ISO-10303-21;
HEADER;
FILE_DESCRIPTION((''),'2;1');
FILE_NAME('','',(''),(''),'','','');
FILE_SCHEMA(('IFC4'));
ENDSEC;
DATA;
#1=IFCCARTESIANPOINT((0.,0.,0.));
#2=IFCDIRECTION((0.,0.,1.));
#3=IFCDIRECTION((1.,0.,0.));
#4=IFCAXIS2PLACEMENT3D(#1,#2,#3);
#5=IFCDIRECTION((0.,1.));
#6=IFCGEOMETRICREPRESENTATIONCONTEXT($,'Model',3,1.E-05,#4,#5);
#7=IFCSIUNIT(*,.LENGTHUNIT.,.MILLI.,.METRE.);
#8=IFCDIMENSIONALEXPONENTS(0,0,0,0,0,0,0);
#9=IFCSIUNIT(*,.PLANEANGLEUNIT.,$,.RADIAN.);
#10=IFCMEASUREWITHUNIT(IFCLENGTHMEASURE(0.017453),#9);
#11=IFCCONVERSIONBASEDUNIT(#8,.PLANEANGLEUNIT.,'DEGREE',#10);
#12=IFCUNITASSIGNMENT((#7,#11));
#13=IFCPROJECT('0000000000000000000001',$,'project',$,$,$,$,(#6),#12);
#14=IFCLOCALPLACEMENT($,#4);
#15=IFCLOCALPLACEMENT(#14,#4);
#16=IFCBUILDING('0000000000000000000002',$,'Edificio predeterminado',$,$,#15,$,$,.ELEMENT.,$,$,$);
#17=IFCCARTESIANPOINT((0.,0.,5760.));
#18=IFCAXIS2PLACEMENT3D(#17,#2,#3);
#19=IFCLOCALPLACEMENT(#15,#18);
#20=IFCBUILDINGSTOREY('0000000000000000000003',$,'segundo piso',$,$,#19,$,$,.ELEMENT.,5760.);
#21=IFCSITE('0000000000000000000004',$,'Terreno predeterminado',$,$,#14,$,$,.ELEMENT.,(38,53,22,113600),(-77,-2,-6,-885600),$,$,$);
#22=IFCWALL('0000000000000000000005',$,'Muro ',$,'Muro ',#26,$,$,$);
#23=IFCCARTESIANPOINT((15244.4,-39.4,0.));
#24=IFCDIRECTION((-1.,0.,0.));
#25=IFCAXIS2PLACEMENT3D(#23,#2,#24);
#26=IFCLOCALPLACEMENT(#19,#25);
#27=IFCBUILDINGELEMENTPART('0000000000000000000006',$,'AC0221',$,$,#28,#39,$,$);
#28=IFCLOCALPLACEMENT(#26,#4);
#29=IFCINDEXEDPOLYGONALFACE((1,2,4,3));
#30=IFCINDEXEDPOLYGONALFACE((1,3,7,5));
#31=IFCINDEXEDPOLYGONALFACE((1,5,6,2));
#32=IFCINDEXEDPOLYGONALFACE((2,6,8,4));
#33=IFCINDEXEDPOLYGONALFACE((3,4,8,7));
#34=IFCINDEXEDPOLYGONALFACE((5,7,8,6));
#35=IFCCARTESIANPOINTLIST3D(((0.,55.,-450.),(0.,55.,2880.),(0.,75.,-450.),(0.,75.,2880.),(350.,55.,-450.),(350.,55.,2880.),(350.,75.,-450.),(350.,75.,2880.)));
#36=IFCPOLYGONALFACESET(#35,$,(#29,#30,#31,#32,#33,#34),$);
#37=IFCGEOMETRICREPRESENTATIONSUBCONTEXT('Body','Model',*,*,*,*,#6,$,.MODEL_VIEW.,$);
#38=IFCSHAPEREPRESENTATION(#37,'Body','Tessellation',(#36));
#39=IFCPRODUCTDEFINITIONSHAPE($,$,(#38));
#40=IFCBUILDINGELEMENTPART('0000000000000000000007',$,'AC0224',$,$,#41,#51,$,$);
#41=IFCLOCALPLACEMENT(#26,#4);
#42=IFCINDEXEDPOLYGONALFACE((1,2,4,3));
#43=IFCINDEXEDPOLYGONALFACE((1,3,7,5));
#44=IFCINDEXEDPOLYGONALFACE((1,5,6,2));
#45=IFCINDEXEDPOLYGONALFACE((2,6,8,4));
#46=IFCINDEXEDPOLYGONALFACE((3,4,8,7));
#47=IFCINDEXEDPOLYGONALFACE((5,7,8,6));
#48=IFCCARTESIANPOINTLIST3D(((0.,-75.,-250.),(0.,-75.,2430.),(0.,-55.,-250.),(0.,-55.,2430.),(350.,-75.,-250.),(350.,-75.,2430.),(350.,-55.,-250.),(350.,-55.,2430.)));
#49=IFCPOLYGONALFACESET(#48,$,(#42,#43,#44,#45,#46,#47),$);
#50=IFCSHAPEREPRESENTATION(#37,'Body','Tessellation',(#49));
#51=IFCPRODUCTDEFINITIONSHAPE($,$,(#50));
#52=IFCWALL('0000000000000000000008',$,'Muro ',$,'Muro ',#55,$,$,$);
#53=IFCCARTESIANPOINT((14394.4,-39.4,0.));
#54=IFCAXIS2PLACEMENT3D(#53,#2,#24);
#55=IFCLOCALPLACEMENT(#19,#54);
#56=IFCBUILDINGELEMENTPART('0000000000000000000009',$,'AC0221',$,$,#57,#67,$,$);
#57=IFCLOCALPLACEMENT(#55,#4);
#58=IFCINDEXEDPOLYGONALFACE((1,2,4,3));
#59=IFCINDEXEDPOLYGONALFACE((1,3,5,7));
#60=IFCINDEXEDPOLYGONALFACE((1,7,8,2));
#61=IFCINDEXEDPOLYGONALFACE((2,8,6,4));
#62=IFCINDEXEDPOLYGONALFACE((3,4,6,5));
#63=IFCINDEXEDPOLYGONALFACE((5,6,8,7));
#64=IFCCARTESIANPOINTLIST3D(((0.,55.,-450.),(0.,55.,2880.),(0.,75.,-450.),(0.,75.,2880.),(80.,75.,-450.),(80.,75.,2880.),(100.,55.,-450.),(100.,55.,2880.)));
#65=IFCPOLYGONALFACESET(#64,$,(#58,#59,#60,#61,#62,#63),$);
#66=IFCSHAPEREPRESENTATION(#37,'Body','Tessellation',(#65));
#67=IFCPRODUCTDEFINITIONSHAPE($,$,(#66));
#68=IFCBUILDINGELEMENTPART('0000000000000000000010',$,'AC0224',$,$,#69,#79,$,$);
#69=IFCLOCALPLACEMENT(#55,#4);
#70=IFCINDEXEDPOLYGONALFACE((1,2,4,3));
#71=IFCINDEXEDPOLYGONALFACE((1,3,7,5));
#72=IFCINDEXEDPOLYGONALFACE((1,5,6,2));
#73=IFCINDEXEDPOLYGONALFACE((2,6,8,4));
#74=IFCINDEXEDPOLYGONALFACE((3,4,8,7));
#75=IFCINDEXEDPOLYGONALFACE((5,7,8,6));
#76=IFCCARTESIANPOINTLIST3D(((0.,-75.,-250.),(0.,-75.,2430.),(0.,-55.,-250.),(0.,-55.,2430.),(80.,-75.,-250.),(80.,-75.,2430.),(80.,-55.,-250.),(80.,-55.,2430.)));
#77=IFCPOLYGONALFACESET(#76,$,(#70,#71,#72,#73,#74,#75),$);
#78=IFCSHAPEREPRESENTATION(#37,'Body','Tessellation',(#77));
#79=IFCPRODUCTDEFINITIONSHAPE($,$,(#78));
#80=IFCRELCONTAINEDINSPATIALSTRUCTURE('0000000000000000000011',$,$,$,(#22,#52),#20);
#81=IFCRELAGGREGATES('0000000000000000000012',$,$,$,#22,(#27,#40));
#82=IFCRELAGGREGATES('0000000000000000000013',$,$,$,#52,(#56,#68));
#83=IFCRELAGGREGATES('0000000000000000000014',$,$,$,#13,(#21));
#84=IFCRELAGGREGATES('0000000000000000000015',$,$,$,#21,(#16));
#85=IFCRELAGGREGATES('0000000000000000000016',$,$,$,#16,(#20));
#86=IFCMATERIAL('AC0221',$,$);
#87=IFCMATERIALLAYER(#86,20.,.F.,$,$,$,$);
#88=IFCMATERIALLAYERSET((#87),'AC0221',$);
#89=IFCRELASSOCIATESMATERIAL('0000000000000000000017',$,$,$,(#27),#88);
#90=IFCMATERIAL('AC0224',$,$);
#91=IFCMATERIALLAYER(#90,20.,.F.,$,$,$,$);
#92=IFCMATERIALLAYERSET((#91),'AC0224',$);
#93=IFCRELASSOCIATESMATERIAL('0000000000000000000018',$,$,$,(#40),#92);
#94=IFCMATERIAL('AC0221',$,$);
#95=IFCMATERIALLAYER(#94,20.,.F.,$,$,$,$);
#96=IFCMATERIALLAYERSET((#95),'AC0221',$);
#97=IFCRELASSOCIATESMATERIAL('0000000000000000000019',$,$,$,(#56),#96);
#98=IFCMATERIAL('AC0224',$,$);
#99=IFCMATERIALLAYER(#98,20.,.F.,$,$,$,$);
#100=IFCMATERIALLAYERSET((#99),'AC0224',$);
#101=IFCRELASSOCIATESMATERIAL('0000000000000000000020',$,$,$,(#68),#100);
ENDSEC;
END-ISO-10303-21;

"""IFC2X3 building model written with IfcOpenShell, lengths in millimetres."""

from ifc_helpers import new_model, entity, si_unit, converted_unit, direction, frame, origin_with_axes, place, context, subcontext, project, spatial, polyline, outline, extrude, material, layer, layer_set, layer_usage, element, aggregate, save


model = new_model("IFC2X3")

# Units and contexts
model_context = context("Model", 3, precision=1e-05, world=origin_with_axes(), true_north=direction((0.0, 1.0)))
body_context = subcontext(model_context, "Body", "Model", "MODEL_VIEW")
ifc_project = project(units=[si_unit("LENGTHUNIT", "METRE", prefix="MILLI"), converted_unit("PLANEANGLEUNIT", "DEGREE", entity("IfcLengthMeasure", 0.017453), si_unit("PLANEANGLEUNIT", "RADIAN"), dimensions=[0, 0, 0, 0, 0, 0, 0])], contexts=[model_context])

# Site, building, storey
site_placement = place(None, origin_with_axes())
site = spatial("IfcSite", under=ifc_project, at=site_placement, Name="Terreno predeterminado", CompositionType="ELEMENT", RefLatitude=(38, 53, 22, 113600), RefLongitude=(-77, -2, -6, -885600))
building_placement = place(site_placement, origin_with_axes())
building = spatial("IfcBuilding", under=site, at=building_placement, Name="Edificio predeterminado", CompositionType="ELEMENT")
storey_placement = place(building_placement, frame((0.0, 0.0, 5760.0), z_axis=(0.0, 0.0, 1.0), x_axis=(1.0, 0.0, 0.0)))
storey = spatial("IfcBuildingStorey", under=building, at=storey_placement, Name="segundo piso", CompositionType="ELEMENT", Elevation=5760.0)

# Walls, building element parts
wall_1_placement = place(storey_placement, frame((15244.4, -39.4, 0.0), z_axis=(0.0, 0.0, 1.0), x_axis=(-1.0, 0.0, 0.0)))
wall_1 = element("IfcWall", 1, at=wall_1_placement, inside=storey, Name="Muro ", ObjectType="Muro ")
ifc_material_1 = material(Name="AC0221")
ifc_layer_1 = layer(ifc_material_1, 20.0, ventilated=False)
ifc_layer_set_1 = layer_set([ifc_layer_1], Name="AC0221")
ifc_layer_usage_1 = layer_usage(ifc_layer_set_1, "AXIS2", "NEGATIVE", -75.0)
building_element_part_1_placement = place(wall_1_placement, origin_with_axes())
building_element_part_1 = element("IfcBuildingElementPart", 2, at=building_element_part_1_placement, material=ifc_layer_usage_1, Name="AC0221", context=body_context, shape_type="SweptSolid", body=[
    extrude(outline(polyline([(350.0, 75.0), (350.0, 55.0), (0.0, 55.0), (0.0, 75.0), (350.0, 75.0)])), frame((0.0, 0.0, -450.0), z_axis=(0.0, 0.0, 1.0), x_axis=(1.0, 0.0, 0.0)), (0.0, 0.0, 1.0), 3330.0),
])
ifc_material_2 = material(Name="AC0224")
ifc_layer_2 = layer(ifc_material_2, 20.0, ventilated=False)
ifc_layer_set_2 = layer_set([ifc_layer_2], Name="AC0224")
ifc_layer_usage_2 = layer_usage(ifc_layer_set_2, "AXIS2", "NEGATIVE", 55.0)
building_element_part_2_placement = place(wall_1_placement, origin_with_axes())
building_element_part_2 = element("IfcBuildingElementPart", 3, at=building_element_part_2_placement, material=ifc_layer_usage_2, Name="AC0224", context=body_context, shape_type="SweptSolid", body=[
    extrude(outline(polyline([(350.0, -55.0), (350.0, -75.0), (0.0, -75.0), (0.0, -55.0), (350.0, -55.0)])), frame((0.0, 0.0, -250.0), z_axis=(0.0, 0.0, 1.0), x_axis=(1.0, 0.0, 0.0)), (0.0, 0.0, 1.0), 2680.0),
])
aggregate(wall_1, [building_element_part_1, building_element_part_2])
wall_2_placement = place(storey_placement, frame((14394.4, -39.4, 0.0), z_axis=(0.0, 0.0, 1.0), x_axis=(-1.0, 0.0, 0.0)))
wall_2 = element("IfcWall", 4, at=wall_2_placement, inside=storey, Name="Muro ", ObjectType="Muro ")
ifc_material_3 = material(Name="AC0221")
ifc_layer_3 = layer(ifc_material_3, 20.0, ventilated=False)
ifc_layer_set_3 = layer_set([ifc_layer_3], Name="AC0221")
ifc_layer_usage_3 = layer_usage(ifc_layer_set_3, "AXIS2", "NEGATIVE", -75.0)
building_element_part_3_placement = place(wall_2_placement, origin_with_axes())
building_element_part_3 = element("IfcBuildingElementPart", 5, at=building_element_part_3_placement, material=ifc_layer_usage_3, Name="AC0221", context=body_context, shape_type="SweptSolid", body=[
    extrude(outline(polyline([(80.0, 75.0), (100.0, 55.0), (0.0, 55.0), (0.0, 75.0), (80.0, 75.0)])), frame((0.0, 0.0, -450.0), z_axis=(0.0, 0.0, 1.0), x_axis=(1.0, 0.0, 0.0)), (0.0, 0.0, 1.0), 3330.0),
])
ifc_material_4 = material(Name="AC0224")
ifc_layer_4 = layer(ifc_material_4, 20.0, ventilated=False)
ifc_layer_set_4 = layer_set([ifc_layer_4], Name="AC0224")
ifc_layer_usage_4 = layer_usage(ifc_layer_set_4, "AXIS2", "NEGATIVE", 55.0)
building_element_part_4_placement = place(wall_2_placement, origin_with_axes())
building_element_part_4 = element("IfcBuildingElementPart", 6, at=building_element_part_4_placement, material=ifc_layer_usage_4, Name="AC0224", context=body_context, shape_type="SweptSolid", body=[
    extrude(outline(polyline([(80.0, -55.0), (80.0, -75.0), (0.0, -75.0), (0.0, -55.0), (80.0, -55.0)])), frame((0.0, 0.0, -250.0), z_axis=(0.0, 0.0, 1.0), x_axis=(1.0, 0.0, 0.0)), (0.0, 0.0, 1.0), 2680.0),
])
aggregate(wall_2, [building_element_part_3, building_element_part_4])

save(model, "model.ifc")
